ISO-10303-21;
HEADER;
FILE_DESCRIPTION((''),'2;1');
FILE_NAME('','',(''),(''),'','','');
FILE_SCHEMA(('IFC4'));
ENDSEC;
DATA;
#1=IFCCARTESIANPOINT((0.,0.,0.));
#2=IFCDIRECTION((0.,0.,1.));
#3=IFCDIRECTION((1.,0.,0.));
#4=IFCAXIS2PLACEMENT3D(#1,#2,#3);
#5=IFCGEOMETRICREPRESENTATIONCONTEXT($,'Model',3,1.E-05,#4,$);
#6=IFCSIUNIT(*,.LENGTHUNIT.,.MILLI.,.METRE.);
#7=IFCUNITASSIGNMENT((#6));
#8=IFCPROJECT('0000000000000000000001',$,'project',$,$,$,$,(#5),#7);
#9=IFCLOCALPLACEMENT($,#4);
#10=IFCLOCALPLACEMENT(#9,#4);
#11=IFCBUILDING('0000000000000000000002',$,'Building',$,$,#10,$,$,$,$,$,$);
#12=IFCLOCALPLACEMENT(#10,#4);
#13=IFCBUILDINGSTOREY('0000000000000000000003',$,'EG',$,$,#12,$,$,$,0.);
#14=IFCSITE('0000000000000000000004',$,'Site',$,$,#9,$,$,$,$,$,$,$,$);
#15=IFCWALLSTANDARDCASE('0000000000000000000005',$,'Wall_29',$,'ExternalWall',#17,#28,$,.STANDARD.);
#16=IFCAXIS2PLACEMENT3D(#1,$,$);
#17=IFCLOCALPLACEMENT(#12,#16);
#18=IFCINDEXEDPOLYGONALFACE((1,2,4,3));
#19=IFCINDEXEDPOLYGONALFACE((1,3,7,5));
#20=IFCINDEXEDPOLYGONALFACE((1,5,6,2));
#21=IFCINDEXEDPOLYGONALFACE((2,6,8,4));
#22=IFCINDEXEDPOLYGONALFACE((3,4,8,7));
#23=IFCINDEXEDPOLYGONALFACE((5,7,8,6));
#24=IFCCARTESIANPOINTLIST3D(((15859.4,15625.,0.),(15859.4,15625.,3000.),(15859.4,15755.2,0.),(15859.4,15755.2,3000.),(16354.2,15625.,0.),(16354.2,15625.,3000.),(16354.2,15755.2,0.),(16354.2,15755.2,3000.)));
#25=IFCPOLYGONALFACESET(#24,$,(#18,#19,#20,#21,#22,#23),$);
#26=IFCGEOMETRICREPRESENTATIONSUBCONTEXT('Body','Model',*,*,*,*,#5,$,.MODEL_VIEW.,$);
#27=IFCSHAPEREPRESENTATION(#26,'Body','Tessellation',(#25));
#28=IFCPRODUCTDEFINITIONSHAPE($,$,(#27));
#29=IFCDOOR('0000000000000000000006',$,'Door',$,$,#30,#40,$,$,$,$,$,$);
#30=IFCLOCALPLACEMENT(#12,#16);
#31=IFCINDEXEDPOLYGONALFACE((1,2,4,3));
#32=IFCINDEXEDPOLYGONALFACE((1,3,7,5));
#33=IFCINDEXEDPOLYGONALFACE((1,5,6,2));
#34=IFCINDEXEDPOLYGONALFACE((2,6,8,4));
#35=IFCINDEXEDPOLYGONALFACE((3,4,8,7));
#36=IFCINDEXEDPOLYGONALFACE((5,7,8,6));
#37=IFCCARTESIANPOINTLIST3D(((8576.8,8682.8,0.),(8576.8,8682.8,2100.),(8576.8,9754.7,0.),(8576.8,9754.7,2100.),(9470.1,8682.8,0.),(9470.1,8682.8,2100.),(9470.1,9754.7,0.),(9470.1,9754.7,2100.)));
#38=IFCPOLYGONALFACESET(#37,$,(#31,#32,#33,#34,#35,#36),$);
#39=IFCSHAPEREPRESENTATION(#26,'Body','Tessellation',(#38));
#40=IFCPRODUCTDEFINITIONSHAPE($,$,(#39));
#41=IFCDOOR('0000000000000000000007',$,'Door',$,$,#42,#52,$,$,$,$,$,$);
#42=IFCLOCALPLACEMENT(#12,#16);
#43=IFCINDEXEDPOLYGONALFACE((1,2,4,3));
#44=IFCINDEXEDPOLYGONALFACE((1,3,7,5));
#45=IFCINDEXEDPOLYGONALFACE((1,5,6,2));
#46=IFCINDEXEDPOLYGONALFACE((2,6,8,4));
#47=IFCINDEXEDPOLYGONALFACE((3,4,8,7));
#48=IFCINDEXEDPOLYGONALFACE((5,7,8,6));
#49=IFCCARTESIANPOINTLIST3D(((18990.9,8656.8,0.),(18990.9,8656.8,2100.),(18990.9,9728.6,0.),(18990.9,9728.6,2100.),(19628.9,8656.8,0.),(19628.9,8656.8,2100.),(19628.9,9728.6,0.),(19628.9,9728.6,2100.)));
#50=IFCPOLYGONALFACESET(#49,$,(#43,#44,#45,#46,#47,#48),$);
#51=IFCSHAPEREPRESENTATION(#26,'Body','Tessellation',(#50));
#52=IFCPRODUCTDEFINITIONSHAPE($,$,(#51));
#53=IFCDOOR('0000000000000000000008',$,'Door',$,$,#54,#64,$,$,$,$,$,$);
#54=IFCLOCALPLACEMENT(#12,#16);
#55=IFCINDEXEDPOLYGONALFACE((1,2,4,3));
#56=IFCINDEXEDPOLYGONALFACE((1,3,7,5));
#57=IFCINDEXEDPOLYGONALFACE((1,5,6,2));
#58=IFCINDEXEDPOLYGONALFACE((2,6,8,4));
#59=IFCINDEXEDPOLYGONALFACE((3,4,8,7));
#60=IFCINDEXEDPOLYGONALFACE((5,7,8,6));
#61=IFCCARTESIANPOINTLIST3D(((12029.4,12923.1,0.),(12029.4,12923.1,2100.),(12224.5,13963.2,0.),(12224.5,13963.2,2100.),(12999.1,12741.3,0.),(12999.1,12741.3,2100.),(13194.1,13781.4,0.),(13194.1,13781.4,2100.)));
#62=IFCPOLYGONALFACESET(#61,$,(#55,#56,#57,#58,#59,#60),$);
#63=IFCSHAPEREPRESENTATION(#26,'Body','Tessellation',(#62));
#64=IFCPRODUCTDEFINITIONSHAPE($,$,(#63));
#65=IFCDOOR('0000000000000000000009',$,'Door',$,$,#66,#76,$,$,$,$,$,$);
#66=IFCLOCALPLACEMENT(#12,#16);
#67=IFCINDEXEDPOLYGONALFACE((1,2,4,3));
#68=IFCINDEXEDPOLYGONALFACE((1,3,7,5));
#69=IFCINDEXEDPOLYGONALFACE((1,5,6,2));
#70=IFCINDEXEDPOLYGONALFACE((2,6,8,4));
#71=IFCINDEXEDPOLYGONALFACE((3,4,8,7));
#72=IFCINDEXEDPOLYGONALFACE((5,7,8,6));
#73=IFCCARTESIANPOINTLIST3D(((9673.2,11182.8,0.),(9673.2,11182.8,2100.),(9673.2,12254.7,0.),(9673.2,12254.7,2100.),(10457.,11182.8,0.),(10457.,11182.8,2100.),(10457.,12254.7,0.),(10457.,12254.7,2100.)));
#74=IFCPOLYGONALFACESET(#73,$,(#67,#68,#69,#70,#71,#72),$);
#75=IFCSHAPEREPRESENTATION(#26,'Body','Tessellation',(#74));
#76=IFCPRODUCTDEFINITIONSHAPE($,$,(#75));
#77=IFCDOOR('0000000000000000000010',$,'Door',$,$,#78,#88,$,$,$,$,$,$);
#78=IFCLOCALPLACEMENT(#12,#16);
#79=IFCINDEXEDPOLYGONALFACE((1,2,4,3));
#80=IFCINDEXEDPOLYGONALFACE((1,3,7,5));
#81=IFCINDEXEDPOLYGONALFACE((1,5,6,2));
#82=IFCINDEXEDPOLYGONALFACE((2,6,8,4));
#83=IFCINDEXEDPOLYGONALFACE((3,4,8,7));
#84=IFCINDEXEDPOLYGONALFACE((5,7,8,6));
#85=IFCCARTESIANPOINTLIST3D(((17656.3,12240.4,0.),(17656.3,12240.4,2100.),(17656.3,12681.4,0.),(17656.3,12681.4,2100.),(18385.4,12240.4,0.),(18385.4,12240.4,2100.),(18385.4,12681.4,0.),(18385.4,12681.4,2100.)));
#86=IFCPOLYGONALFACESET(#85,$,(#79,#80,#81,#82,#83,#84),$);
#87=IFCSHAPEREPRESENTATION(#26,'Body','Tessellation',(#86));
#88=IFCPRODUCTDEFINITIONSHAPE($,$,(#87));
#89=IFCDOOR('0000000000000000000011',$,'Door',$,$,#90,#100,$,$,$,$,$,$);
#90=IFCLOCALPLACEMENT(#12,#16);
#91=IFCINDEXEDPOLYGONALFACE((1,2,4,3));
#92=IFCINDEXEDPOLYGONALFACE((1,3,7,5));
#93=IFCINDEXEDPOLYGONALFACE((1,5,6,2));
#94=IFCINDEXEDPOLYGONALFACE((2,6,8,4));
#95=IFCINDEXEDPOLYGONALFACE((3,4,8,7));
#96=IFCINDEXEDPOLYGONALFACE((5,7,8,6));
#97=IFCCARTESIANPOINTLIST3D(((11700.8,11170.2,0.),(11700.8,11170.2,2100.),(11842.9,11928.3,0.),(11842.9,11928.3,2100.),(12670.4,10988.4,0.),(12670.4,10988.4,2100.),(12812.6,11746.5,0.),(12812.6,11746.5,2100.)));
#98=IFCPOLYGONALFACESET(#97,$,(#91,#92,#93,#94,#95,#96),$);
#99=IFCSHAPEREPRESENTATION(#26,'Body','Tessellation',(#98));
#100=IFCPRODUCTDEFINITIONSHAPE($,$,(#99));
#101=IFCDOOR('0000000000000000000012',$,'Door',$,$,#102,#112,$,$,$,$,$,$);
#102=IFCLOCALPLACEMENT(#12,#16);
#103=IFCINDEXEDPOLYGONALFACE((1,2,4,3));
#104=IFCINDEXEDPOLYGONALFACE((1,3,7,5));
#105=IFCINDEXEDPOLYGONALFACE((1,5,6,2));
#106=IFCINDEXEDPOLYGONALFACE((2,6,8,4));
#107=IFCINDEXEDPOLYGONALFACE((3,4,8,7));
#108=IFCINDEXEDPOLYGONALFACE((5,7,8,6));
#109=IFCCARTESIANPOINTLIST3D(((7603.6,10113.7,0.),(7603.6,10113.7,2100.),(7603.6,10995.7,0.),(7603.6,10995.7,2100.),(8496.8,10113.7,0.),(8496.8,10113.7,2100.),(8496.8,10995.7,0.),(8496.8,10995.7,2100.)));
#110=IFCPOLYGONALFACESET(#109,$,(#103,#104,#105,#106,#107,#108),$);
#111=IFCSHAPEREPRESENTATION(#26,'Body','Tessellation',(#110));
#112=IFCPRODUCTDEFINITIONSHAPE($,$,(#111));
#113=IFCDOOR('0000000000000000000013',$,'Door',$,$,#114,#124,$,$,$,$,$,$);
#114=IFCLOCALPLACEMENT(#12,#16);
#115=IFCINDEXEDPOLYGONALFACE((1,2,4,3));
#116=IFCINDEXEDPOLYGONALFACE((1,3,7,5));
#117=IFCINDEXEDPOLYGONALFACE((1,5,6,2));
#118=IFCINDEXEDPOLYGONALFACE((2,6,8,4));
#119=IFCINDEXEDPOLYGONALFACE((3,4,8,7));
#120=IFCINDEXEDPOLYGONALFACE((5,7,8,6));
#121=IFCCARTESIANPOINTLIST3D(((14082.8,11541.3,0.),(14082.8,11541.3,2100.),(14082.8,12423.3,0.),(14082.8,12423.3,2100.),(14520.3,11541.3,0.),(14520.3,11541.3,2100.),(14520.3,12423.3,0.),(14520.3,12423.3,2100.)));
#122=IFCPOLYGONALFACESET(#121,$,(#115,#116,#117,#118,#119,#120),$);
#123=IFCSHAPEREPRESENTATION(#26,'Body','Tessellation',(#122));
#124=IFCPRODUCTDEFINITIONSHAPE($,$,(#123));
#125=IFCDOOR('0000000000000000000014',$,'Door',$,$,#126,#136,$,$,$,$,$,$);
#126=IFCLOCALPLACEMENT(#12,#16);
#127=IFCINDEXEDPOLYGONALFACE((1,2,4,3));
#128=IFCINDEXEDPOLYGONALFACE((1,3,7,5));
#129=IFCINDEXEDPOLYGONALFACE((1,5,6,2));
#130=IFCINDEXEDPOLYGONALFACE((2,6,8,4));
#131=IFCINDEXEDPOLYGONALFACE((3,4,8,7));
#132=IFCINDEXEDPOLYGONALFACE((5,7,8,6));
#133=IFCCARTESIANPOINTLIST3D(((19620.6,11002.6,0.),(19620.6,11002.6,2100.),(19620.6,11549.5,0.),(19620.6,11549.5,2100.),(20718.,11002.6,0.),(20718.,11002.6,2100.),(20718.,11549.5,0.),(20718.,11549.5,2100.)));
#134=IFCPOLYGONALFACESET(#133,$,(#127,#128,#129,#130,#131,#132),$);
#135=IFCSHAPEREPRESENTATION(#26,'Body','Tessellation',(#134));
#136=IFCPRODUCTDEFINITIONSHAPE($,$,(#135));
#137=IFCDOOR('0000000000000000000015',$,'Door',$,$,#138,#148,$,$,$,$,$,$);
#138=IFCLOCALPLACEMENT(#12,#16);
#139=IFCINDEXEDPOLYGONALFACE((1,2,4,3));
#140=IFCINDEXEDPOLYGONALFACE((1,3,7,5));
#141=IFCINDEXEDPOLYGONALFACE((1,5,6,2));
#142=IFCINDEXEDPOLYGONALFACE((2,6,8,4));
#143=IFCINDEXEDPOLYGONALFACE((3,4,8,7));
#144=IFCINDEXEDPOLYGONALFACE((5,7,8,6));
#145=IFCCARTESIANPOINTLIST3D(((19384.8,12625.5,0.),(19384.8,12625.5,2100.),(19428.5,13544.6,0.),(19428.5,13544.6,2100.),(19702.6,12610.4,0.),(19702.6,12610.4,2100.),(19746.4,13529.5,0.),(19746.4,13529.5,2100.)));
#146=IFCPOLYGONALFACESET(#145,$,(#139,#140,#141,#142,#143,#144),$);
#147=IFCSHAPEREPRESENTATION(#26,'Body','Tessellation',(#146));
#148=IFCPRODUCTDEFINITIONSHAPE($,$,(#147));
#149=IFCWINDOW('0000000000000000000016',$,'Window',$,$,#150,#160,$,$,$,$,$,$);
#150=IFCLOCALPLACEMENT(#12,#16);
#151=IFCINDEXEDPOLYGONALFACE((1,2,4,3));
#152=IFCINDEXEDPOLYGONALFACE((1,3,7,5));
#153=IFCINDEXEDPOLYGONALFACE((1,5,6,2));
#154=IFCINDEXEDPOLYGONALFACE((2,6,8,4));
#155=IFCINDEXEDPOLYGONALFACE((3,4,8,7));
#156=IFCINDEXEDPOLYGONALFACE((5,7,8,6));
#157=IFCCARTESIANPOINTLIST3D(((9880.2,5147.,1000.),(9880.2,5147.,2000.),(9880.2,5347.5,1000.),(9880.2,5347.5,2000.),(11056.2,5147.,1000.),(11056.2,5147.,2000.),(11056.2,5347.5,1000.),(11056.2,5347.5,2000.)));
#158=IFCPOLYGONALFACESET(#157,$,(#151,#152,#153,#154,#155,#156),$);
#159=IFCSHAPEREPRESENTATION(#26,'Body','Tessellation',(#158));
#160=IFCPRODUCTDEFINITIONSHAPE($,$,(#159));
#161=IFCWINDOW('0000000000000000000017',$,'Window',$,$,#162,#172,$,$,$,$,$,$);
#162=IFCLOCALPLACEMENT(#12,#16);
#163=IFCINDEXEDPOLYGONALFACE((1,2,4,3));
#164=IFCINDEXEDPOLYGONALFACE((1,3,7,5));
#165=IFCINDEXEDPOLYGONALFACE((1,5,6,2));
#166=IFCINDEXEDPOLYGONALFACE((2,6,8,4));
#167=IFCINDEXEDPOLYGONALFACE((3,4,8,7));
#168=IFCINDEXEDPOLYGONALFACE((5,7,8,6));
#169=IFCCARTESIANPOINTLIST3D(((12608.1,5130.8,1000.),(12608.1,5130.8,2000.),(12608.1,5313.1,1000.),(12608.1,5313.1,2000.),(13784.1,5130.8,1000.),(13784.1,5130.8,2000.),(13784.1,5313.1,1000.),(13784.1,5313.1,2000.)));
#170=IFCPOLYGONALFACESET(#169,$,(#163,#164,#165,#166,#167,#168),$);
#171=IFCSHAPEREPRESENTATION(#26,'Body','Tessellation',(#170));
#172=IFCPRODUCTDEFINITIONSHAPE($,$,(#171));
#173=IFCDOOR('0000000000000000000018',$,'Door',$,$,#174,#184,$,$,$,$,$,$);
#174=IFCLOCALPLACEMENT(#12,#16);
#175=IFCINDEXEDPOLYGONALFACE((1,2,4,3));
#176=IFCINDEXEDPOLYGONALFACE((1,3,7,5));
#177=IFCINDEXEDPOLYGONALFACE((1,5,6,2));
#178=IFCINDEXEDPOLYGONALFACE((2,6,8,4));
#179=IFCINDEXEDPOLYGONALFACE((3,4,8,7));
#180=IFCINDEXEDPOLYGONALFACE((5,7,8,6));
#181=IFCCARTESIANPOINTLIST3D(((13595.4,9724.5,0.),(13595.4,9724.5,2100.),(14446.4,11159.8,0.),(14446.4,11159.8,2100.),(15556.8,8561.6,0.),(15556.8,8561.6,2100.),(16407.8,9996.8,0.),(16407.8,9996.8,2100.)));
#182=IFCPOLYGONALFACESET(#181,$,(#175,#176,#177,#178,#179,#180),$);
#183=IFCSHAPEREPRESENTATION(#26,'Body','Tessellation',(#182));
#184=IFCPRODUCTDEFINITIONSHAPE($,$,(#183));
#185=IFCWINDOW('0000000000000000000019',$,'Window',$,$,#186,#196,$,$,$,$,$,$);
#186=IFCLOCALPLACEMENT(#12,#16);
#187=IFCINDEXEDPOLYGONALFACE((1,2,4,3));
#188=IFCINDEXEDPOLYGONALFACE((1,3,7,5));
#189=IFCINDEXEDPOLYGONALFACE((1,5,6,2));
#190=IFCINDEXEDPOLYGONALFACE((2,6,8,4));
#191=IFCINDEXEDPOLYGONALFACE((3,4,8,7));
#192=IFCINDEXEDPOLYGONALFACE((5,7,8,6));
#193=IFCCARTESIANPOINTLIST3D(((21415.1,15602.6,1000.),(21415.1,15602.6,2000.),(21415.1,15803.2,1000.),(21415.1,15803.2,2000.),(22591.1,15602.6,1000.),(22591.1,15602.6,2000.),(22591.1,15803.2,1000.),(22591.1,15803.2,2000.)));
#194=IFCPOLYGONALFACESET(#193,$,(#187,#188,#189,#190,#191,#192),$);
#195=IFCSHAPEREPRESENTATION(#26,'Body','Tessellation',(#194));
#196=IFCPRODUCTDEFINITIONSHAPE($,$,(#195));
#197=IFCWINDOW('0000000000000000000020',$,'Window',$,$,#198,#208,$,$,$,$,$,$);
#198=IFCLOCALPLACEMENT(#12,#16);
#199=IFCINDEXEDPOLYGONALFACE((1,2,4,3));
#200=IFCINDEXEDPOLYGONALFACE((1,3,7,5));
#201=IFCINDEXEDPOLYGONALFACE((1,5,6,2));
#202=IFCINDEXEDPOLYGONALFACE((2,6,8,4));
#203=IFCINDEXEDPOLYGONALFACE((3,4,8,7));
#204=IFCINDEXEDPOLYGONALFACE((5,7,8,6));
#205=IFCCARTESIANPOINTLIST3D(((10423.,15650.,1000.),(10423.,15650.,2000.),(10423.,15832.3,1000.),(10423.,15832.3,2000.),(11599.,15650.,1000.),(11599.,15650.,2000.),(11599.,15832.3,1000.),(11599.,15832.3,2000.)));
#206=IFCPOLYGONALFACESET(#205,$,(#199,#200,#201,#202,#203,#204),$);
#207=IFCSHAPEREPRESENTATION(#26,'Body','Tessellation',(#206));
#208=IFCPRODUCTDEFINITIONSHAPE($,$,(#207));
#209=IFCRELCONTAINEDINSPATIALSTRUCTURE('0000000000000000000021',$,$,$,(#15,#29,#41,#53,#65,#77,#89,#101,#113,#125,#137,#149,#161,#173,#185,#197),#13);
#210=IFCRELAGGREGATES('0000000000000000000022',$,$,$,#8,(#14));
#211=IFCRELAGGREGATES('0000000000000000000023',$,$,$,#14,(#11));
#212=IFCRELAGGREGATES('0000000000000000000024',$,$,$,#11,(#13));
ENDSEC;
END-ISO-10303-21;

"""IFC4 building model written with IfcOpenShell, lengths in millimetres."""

from ifc_helpers import new_model, si_unit, frame, origin_with_axes, place, context, subcontext, project, spatial, polyline, rectangle, outline, extrude, element, save


model = new_model("IFC4")

# Units and contexts
model_context = context("Model", 3, precision=1e-05, world=origin_with_axes())
body_context = subcontext(model_context, "Body", "Model", "MODEL_VIEW")
ifc_project = project(units=[si_unit("LENGTHUNIT", "METRE", prefix="MILLI")], contexts=[model_context])

# Site, building, storey
site_placement = place(None, origin_with_axes())
site = spatial("IfcSite", under=ifc_project, at=site_placement, Name="Site")
building_placement = place(site_placement, origin_with_axes())
building = spatial("IfcBuilding", under=site, at=building_placement, Name="Building")
storey_placement = place(building_placement, origin_with_axes())
storey = spatial("IfcBuildingStorey", under=building, at=storey_placement, Name="EG", Elevation=0.0)

# Wall
wall_placement = place(storey_placement, origin_with_axes())
element("IfcWallStandardCase", 1, at=wall_placement, inside=storey, Name="Wall_29", ObjectType="ExternalWall", PredefinedType="STANDARD", context=body_context, shape_type="SweptSolid", body=[
    extrude(outline(polyline([(15859.4, 15625.0, 0.0), (15859.4, 15755.2, 0.0), (16354.2, 15755.2, 0.0), (16354.2, 15625.0, 0.0), (15859.4, 15625.0, 0.0)])), origin_with_axes(), (0.0, 0.0, 1.0), 3000.0),
])

# Doors
door_1_placement = place(storey_placement, origin_with_axes())
element("IfcDoor", 2, at=door_1_placement, inside=storey, Name="Door", context=body_context, shape_type="SweptSolid", body=[
    extrude(rectangle(XDim=1071.9, YDim=893.2), frame((9023.4, 9218.8, 0.0), z_axis=(0.0, 0.0, 1.0), x_axis=(0.0, 1.0, 0.0)), (0.0, 0.0, 1.0), 2100.0),
])
door_2_placement = place(storey_placement, origin_with_axes())
element("IfcDoor", 3, at=door_2_placement, inside=storey, Name="Door", context=body_context, shape_type="SweptSolid", body=[
    extrude(rectangle(XDim=1071.9, YDim=638.0), frame((19309.9, 9192.7, 0.0), z_axis=(0.0, 0.0, 1.0), x_axis=(0.0, 1.0, 0.0)), (0.0, 0.0, 1.0), 2100.0),
])
door_3_placement = place(storey_placement, origin_with_axes())
element("IfcDoor", 4, at=door_3_placement, inside=storey, Name="Door", context=body_context, shape_type="SweptSolid", body=[
    extrude(rectangle(XDim=1058.2, YDim=986.6), frame((12611.8, 13352.3, 0.0), z_axis=(0.0, 0.0, 1.0), x_axis=(0.184288, 0.982872, 0.0)), (0.0, 0.0, 1.0), 2100.0),
])
door_4_placement = place(storey_placement, origin_with_axes())
element("IfcDoor", 5, at=door_4_placement, inside=storey, Name="Door", context=body_context, shape_type="SweptSolid", body=[
    extrude(rectangle(XDim=1071.9, YDim=783.9), frame((10065.1, 11718.8, 0.0), z_axis=(0.0, 0.0, 1.0), x_axis=(0.0, -1.0, 0.0)), (0.0, 0.0, 1.0), 2100.0),
])
door_5_placement = place(storey_placement, origin_with_axes())
element("IfcDoor", 6, at=door_5_placement, inside=storey, Name="Door", context=body_context, shape_type="SweptSolid", body=[
    extrude(rectangle(XDim=441.0, YDim=729.2), frame((18020.8, 12460.9, 0.0), z_axis=(0.0, 0.0, 1.0), x_axis=(0.0, 1.0, 0.0)), (0.0, 0.0, 1.0), 2100.0),
])
door_6_placement = place(storey_placement, origin_with_axes())
element("IfcDoor", 7, at=door_6_placement, inside=storey, Name="Door", context=body_context, shape_type="SweptSolid", body=[
    extrude(rectangle(XDim=771.3, YDim=986.6), frame((12256.7, 11458.4, 0.0), z_axis=(0.0, 0.0, 1.0), x_axis=(0.184288, 0.982872, 0.0)), (0.0, 0.0, 1.0), 2100.0),
])
door_7_placement = place(storey_placement, origin_with_axes())
element("IfcDoor", 8, at=door_7_placement, inside=storey, Name="Door", context=body_context, shape_type="SweptSolid", body=[
    extrude(rectangle(XDim=882.0, YDim=893.2), frame((8050.2, 10554.7, 0.0), z_axis=(0.0, 0.0, 1.0), x_axis=(0.0, 1.0, 0.0)), (0.0, 0.0, 1.0), 2100.0),
])
door_8_placement = place(storey_placement, origin_with_axes())
element("IfcDoor", 9, at=door_8_placement, inside=storey, Name="Door", context=body_context, shape_type="SweptSolid", body=[
    extrude(rectangle(XDim=882.0, YDim=437.5), frame((14301.5, 11982.3, 0.0), z_axis=(0.0, 0.0, 1.0), x_axis=(0.0, 1.0, 0.0)), (0.0, 0.0, 1.0), 2100.0),
])
door_9_placement = place(storey_placement, origin_with_axes())
element("IfcDoor", 10, at=door_9_placement, inside=storey, Name="Door", context=body_context, shape_type="SweptSolid", body=[
    extrude(rectangle(XDim=1097.4, YDim=546.9), frame((20169.3, 11276.0, 0.0), z_axis=(0.0, 0.0, 1.0), x_axis=(1.0, 0.0, 0.0)), (0.0, 0.0, 1.0), 2100.0),
])
door_10_placement = place(storey_placement, origin_with_axes())
element("IfcDoor", 11, at=door_10_placement, inside=storey, Name="Door", context=body_context, shape_type="SweptSolid", body=[
    extrude(rectangle(XDim=920.1, YDim=318.2), frame((19565.6, 13077.5, 0.0), z_axis=(0.0, 0.0, 1.0), x_axis=(-0.047565, -0.998868, 0.0)), (0.0, 0.0, 1.0), 2100.0),
])

# Windows
window_1_placement = place(storey_placement, origin_with_axes())
element("IfcWindow", 12, at=window_1_placement, inside=storey, Name="Window", context=body_context, shape_type="SweptSolid", body=[
    extrude(rectangle(XDim=1176.0, YDim=200.5), frame((10468.2, 5247.3, 1000.0), z_axis=(0.0, 0.0, 1.0), x_axis=(-1.0, 0.0, 0.0)), (0.0, 0.0, 1.0), 1000.0),
])
window_2_placement = place(storey_placement, origin_with_axes())
element("IfcWindow", 13, at=window_2_placement, inside=storey, Name="Window", context=body_context, shape_type="SweptSolid", body=[
    extrude(rectangle(XDim=1176.0, YDim=182.3), frame((13196.1, 5222.0, 1000.0), z_axis=(0.0, 0.0, 1.0), x_axis=(1.0, 0.0, 0.0)), (0.0, 0.0, 1.0), 1000.0),
])

# Door
door_11_placement = place(storey_placement, origin_with_axes())
element("IfcDoor", 14, at=door_11_placement, inside=storey, Name="Door", context=body_context, shape_type="SweptSolid", body=[
    extrude(rectangle(XDim=1668.6, YDim=2280.3), frame((15001.6, 9860.7, 0.0), z_axis=(0.0, 0.0, 1.0), x_axis=(-0.510011, -0.860168, 0.0)), (0.0, 0.0, 1.0), 2100.0),
])

# Windows
window_3_placement = place(storey_placement, origin_with_axes())
element("IfcWindow", 15, at=window_3_placement, inside=storey, Name="Window", context=body_context, shape_type="SweptSolid", body=[
    extrude(rectangle(XDim=1176.0, YDim=200.5), frame((22003.1, 15702.9, 1000.0), z_axis=(0.0, 0.0, 1.0), x_axis=(1.0, 0.0, 0.0)), (0.0, 0.0, 1.0), 1000.0),
])
window_4_placement = place(storey_placement, origin_with_axes())
element("IfcWindow", 16, at=window_4_placement, inside=storey, Name="Window", context=body_context, shape_type="SweptSolid", body=[
    extrude(rectangle(XDim=1176.0, YDim=182.3), frame((11011.0, 15741.2, 1000.0), z_axis=(0.0, 0.0, 1.0), x_axis=(1.0, 0.0, 0.0)), (0.0, 0.0, 1.0), 1000.0),
])

save(model, "model.ifc")
